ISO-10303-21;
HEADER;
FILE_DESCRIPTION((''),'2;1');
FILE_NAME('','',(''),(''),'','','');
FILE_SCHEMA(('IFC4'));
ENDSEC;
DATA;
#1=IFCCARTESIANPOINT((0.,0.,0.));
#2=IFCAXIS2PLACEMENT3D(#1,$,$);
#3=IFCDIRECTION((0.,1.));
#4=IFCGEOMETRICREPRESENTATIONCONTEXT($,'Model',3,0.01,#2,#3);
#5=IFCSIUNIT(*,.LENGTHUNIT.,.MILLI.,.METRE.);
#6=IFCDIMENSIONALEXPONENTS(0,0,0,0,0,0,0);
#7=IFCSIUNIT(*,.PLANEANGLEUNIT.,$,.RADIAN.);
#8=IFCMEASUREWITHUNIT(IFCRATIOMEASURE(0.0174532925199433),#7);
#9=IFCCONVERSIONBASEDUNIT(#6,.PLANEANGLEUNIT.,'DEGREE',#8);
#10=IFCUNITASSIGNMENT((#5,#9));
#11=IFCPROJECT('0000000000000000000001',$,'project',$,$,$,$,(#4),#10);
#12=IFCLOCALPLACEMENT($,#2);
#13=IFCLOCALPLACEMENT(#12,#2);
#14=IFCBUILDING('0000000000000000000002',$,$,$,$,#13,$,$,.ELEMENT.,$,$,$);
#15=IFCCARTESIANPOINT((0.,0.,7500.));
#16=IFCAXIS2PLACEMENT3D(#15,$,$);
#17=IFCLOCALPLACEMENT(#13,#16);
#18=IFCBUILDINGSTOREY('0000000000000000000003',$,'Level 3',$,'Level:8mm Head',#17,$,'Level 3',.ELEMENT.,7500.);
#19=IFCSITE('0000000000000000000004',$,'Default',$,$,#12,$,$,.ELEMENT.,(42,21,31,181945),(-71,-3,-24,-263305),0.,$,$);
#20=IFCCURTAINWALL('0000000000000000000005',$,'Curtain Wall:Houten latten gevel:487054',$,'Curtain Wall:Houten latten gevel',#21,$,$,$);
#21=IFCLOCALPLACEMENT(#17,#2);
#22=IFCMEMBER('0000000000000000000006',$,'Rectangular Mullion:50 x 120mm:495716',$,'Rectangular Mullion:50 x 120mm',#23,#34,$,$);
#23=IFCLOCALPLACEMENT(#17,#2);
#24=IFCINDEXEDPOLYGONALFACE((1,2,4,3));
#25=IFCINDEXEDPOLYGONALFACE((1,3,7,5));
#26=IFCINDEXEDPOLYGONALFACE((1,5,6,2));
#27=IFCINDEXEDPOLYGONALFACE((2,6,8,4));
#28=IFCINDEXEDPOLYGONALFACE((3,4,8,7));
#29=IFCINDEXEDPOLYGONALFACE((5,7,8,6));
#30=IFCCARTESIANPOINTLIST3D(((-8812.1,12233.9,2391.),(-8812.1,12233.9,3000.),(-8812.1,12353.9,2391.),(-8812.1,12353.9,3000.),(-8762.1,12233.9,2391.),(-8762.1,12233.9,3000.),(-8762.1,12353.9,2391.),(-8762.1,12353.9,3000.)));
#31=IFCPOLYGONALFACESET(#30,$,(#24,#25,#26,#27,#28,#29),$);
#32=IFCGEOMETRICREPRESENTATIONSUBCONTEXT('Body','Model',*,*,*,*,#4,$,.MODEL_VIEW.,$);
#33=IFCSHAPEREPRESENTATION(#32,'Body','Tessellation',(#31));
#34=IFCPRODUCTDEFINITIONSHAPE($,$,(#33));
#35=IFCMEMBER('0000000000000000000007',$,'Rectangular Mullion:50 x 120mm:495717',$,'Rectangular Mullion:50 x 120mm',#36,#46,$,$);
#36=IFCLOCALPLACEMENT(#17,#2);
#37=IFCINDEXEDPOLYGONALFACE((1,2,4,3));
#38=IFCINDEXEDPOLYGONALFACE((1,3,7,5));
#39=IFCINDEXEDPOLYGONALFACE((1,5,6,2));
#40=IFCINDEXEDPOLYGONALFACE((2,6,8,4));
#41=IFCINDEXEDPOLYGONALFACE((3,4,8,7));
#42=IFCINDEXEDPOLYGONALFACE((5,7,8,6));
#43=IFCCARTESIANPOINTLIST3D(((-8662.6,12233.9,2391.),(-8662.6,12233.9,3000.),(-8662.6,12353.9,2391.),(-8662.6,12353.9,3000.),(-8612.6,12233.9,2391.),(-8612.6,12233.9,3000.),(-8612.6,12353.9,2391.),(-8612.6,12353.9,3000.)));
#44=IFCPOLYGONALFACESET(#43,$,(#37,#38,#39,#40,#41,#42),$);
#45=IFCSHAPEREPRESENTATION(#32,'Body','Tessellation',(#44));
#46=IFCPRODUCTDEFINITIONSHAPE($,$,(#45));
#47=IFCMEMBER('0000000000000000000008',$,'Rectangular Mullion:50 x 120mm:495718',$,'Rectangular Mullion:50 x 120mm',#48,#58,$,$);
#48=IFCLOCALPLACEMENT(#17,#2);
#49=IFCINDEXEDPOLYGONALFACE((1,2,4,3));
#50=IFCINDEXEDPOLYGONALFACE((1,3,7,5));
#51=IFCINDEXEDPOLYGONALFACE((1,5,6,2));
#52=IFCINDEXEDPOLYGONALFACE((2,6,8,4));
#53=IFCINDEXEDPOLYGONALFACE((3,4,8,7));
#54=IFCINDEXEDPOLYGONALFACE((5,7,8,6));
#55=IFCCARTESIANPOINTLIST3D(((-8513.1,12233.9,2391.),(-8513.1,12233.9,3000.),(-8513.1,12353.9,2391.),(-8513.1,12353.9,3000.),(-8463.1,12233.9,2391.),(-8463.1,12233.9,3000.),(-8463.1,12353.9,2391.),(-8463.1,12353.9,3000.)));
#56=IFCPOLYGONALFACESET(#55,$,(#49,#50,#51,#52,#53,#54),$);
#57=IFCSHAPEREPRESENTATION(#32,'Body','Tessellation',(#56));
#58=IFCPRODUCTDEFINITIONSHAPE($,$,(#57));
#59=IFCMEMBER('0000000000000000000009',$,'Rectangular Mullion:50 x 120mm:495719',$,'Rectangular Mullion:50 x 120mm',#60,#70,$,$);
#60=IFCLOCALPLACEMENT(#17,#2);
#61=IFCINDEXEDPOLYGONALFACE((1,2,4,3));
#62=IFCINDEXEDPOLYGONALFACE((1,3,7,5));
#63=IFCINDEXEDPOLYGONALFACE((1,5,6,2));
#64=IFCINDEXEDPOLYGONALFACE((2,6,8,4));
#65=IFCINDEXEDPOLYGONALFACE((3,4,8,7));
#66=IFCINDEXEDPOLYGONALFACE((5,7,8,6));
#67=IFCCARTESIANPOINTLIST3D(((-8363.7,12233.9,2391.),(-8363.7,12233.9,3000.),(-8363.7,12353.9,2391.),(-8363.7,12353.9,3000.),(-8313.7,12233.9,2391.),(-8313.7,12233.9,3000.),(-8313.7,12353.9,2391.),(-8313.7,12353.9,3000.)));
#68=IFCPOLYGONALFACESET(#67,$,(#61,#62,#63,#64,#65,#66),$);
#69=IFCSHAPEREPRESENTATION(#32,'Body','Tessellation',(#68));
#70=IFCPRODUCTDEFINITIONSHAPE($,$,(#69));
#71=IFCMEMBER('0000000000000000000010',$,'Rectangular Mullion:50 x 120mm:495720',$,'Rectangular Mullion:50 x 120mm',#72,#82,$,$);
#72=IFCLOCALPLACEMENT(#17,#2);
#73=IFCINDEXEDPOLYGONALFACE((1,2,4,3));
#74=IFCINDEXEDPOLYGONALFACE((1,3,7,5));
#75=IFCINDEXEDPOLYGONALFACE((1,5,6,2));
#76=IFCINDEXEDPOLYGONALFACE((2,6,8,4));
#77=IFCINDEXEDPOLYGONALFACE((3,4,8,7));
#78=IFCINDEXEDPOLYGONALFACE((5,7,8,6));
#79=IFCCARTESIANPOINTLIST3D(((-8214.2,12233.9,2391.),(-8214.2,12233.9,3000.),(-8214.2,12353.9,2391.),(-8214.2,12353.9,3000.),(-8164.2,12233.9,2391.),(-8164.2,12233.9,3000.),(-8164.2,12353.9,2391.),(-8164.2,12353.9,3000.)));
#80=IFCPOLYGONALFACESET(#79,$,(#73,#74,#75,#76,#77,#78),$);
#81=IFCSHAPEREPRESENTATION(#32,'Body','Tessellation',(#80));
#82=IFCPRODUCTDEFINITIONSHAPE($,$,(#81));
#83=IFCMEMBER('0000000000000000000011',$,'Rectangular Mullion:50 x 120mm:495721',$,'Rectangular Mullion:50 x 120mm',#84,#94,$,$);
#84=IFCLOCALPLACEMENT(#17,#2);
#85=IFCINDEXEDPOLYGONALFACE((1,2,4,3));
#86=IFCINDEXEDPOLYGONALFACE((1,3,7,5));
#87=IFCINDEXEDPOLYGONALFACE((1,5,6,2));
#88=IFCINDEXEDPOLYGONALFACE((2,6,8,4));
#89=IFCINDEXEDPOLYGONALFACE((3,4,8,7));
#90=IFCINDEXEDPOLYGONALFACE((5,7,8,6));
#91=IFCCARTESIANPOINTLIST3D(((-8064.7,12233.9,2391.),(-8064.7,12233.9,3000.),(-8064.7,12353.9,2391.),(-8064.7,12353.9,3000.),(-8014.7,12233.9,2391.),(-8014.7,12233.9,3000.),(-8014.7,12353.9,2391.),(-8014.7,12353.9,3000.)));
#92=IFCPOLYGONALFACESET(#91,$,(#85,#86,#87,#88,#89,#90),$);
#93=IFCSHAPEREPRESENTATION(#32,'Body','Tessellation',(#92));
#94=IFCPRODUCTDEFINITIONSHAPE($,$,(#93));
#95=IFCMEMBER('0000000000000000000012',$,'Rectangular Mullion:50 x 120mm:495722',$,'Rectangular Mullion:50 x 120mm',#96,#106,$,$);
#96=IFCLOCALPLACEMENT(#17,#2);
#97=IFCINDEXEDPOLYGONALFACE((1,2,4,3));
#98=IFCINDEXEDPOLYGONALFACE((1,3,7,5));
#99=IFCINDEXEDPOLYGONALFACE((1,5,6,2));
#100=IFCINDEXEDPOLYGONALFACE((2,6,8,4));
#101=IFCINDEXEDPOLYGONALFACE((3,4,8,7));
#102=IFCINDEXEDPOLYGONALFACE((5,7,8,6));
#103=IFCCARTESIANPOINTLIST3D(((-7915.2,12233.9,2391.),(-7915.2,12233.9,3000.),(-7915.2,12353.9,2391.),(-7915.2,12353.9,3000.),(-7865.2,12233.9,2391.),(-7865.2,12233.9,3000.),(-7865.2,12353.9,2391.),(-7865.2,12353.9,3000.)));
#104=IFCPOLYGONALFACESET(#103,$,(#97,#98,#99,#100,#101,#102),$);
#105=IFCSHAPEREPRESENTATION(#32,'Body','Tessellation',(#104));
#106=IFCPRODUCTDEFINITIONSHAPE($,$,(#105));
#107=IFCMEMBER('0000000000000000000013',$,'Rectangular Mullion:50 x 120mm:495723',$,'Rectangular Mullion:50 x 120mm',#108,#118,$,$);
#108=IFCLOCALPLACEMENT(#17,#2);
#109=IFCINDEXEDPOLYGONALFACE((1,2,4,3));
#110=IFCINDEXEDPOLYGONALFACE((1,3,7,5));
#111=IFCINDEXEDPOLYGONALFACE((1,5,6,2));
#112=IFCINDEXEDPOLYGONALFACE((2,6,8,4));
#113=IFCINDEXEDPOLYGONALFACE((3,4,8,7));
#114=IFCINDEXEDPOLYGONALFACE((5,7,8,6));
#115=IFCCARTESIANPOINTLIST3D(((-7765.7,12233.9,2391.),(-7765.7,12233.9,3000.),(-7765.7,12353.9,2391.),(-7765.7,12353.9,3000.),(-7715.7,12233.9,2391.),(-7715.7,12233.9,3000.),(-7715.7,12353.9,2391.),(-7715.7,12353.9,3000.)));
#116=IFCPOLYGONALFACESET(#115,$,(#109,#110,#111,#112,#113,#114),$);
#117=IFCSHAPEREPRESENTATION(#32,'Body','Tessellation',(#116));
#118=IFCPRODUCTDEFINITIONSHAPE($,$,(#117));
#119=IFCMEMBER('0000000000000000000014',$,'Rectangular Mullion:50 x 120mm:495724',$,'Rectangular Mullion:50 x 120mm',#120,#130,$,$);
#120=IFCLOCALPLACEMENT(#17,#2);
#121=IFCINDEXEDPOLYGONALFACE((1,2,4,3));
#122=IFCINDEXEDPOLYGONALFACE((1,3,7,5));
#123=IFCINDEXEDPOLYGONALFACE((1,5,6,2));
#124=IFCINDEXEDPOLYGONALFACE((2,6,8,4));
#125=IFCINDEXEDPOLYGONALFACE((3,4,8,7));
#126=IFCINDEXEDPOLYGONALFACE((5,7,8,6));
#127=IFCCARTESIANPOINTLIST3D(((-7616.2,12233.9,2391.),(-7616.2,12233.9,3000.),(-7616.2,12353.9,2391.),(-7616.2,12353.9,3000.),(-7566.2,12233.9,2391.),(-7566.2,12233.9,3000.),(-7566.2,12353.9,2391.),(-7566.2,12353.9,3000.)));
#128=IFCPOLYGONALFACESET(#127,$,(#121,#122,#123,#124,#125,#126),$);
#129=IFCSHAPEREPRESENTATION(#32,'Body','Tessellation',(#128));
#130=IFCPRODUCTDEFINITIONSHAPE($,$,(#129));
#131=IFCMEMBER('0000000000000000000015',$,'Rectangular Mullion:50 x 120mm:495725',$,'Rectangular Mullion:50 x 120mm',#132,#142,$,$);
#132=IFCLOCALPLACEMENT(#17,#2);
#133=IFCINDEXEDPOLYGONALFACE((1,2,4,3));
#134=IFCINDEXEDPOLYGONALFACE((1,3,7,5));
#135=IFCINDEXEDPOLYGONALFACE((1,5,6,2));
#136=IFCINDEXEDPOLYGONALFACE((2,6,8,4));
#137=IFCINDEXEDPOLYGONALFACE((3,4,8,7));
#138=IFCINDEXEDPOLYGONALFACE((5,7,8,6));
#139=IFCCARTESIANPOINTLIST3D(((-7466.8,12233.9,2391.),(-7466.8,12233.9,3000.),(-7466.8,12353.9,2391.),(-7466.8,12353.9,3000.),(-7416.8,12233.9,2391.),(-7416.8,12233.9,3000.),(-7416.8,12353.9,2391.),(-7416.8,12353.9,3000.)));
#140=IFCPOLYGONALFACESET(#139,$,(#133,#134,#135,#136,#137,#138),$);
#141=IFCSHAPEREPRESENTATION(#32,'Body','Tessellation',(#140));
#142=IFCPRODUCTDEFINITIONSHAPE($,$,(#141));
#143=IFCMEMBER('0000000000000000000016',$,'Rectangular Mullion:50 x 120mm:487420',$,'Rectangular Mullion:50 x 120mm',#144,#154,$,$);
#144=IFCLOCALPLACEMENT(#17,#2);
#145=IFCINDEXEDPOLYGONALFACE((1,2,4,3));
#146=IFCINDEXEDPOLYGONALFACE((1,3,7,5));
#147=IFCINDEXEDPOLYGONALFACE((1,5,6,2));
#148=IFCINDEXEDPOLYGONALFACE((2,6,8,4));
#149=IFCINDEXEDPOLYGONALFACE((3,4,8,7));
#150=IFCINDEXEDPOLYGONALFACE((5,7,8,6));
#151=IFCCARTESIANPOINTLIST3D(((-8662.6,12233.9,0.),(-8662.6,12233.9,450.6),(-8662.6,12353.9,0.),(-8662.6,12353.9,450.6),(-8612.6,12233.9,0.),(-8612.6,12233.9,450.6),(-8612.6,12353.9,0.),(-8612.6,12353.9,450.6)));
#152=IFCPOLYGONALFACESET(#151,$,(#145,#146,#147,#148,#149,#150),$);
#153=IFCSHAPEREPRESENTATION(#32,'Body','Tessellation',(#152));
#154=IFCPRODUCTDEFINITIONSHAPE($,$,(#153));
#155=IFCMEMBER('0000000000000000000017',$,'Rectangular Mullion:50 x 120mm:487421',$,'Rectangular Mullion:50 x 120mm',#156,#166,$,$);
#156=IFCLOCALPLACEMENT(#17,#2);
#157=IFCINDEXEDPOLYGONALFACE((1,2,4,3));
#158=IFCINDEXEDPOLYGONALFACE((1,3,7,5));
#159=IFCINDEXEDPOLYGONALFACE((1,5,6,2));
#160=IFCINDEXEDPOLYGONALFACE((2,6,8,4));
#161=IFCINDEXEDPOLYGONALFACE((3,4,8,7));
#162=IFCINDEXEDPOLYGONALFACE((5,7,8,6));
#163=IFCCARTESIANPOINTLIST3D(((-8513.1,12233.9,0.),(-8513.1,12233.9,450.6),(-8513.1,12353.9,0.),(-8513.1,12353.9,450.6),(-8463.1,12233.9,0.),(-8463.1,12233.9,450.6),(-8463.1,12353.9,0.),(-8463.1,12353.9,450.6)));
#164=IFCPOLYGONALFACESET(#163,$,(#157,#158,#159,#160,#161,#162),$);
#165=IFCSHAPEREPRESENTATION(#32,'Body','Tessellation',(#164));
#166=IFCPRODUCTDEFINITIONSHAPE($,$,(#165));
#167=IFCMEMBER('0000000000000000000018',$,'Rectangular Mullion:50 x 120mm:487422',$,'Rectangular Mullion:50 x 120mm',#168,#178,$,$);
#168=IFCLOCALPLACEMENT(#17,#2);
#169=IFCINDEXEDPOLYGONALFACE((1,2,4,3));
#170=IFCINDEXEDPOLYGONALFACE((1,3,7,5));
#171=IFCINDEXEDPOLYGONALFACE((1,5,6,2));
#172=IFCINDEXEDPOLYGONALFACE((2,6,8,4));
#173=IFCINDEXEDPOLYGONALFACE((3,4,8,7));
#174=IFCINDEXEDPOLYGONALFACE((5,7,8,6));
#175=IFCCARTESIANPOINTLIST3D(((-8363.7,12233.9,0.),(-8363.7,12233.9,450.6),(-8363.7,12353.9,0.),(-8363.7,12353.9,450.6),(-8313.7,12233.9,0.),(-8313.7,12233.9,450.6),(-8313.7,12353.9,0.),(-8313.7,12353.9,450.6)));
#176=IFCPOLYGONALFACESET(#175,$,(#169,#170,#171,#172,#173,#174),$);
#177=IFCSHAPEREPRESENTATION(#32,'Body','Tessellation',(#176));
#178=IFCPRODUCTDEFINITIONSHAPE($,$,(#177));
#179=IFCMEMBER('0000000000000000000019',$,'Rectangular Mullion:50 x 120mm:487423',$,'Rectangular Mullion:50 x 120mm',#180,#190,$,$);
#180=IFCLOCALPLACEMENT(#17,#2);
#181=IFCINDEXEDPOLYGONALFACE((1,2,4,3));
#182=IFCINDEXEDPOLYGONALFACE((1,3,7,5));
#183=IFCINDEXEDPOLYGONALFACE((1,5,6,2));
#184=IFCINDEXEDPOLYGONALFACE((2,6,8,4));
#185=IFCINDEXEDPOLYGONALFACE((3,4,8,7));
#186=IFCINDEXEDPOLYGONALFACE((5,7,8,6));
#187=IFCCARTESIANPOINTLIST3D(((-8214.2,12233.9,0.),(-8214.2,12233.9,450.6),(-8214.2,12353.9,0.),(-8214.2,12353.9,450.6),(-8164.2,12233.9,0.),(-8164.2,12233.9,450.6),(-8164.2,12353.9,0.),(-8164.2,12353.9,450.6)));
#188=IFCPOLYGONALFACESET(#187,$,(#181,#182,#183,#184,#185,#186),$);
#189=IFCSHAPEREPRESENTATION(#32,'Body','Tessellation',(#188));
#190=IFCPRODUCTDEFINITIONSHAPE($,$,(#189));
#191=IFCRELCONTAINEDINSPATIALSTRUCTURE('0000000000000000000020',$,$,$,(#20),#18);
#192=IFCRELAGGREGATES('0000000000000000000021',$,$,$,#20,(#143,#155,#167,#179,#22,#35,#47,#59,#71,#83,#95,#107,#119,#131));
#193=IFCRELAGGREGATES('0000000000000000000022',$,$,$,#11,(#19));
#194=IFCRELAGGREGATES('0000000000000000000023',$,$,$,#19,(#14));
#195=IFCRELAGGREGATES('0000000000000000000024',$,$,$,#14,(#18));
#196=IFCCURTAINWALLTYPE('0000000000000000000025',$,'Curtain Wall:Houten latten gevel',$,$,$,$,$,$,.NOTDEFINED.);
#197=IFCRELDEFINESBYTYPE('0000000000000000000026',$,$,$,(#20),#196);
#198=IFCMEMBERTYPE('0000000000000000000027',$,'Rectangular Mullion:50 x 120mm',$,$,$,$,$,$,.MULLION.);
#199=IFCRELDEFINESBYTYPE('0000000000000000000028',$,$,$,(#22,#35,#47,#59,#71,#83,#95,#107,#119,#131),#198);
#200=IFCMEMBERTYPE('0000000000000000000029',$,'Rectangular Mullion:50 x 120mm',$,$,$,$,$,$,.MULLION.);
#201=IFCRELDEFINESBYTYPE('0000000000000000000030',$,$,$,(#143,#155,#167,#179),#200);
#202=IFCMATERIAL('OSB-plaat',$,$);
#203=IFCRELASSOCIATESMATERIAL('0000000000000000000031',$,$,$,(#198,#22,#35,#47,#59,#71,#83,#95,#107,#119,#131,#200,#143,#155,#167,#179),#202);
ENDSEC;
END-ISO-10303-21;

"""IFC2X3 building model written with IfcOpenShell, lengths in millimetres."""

from ifc_helpers import new_model, entity, si_unit, converted_unit, direction, frame, origin, origin_2d_with_axis, place, context, subcontext, project, spatial, rectangle, extrude, source, transform, mapped, material, type_object, type_shapes, element, aggregate, save


model = new_model("IFC2X3")

# Units and contexts
model_context = context("Model", 3, precision=0.01, world=origin(), true_north=direction((0.0, 1.0)))
body_context = subcontext(model_context, "Body", "Model", "MODEL_VIEW")
ifc_project = project(units=[si_unit("LENGTHUNIT", "METRE", prefix="MILLI"), converted_unit("PLANEANGLEUNIT", "DEGREE", entity("IfcRatioMeasure", 0.0174532925199433), si_unit("PLANEANGLEUNIT", "RADIAN"), dimensions=[0, 0, 0, 0, 0, 0, 0])], contexts=[model_context])

# Site, building, storey
site_placement = place(None, frame((0.0, 0.0, 0.0)))
site = spatial("IfcSite", under=ifc_project, at=site_placement, Name="Default", CompositionType="ELEMENT", RefLatitude=(42, 21, 31, 181945), RefLongitude=(-71, -3, -24, -263305), RefElevation=0.0)
building_placement = place(site_placement, origin())
building = spatial("IfcBuilding", under=site, at=building_placement, CompositionType="ELEMENT")
storey_placement = place(building_placement, frame((0.0, 0.0, 7500.0)))
storey = spatial("IfcBuildingStorey", under=building, at=storey_placement, Name="Level 3", ObjectType="Level:8mm Head", LongName="Level 3", CompositionType="ELEMENT", Elevation=7500.0)

# Curtain wall, members
curtain_wall_type = type_object("IfcCurtainWallType", Name="Curtain Wall:Houten latten gevel", PredefinedType="NOTDEFINED")
curtain_wall_placement = place(storey_placement, frame((0.0, 0.0, -7500.0)))
curtain_wall = element("IfcCurtainWall", 1, at=curtain_wall_placement, inside=storey, type_object=curtain_wall_type, Name="Curtain Wall:Houten latten gevel:487054", ObjectType="Curtain Wall:Houten latten gevel")
ifc_material_1 = material(Name="OSB-plaat")
member_type_1 = type_object("IfcMemberType", Name="Rectangular Mullion:50 x 120mm", PredefinedType="MULLION", material=ifc_material_1)
shared_shape_1 = source(origin(), body_context, "Body", "SweptSolid", [
    extrude(rectangle(XDim=120.0, YDim=50.0, at=origin_2d_with_axis()), frame((0.0, 0.0, -609.0), z_axis=(0.0, 0.0, 1.0), x_axis=(0.0, -1.0, 0.0)), (0.0, 0.0, 1.0), 609.0),
])
type_shapes(member_type_1, [shared_shape_1])
member_1_placement = place(storey_placement, frame((-8787.1, 12293.9, 2391.0), z_axis=(0.0, 0.0, -1.0), x_axis=(1.0, 0.0, 0.0)))
member_1 = element("IfcMember", 2, at=member_1_placement, type_object=member_type_1, material=ifc_material_1, Name="Rectangular Mullion:50 x 120mm:495716", ObjectType="Rectangular Mullion:50 x 120mm", context=body_context, shape_type="MappedRepresentation", body=[
    mapped(shared_shape_1, transform((0.0, 0.0, 0.0), scale=1.0)),
])
member_2_placement = place(storey_placement, frame((-8637.6, 12293.9, 2391.0), z_axis=(0.0, 0.0, -1.0), x_axis=(1.0, 0.0, 0.0)))
member_2 = element("IfcMember", 3, at=member_2_placement, type_object=member_type_1, material=ifc_material_1, Name="Rectangular Mullion:50 x 120mm:495717", ObjectType="Rectangular Mullion:50 x 120mm", context=body_context, shape_type="MappedRepresentation", body=[
    mapped(shared_shape_1, transform((0.0, 0.0, 0.0), scale=1.0)),
])
member_3_placement = place(storey_placement, frame((-8488.1, 12293.9, 2391.0), z_axis=(0.0, 0.0, -1.0), x_axis=(1.0, 0.0, 0.0)))
member_3 = element("IfcMember", 4, at=member_3_placement, type_object=member_type_1, material=ifc_material_1, Name="Rectangular Mullion:50 x 120mm:495718", ObjectType="Rectangular Mullion:50 x 120mm", context=body_context, shape_type="MappedRepresentation", body=[
    mapped(shared_shape_1, transform((0.0, 0.0, 0.0), scale=1.0)),
])
member_4_placement = place(storey_placement, frame((-8338.7, 12293.9, 2391.0), z_axis=(0.0, 0.0, -1.0), x_axis=(1.0, 0.0, 0.0)))
member_4 = element("IfcMember", 5, at=member_4_placement, type_object=member_type_1, material=ifc_material_1, Name="Rectangular Mullion:50 x 120mm:495719", ObjectType="Rectangular Mullion:50 x 120mm", context=body_context, shape_type="MappedRepresentation", body=[
    mapped(shared_shape_1, transform((0.0, 0.0, 0.0), scale=1.0)),
])
member_5_placement = place(storey_placement, frame((-8189.2, 12293.9, 2391.0), z_axis=(0.0, 0.0, -1.0), x_axis=(1.0, 0.0, 0.0)))
member_5 = element("IfcMember", 6, at=member_5_placement, type_object=member_type_1, material=ifc_material_1, Name="Rectangular Mullion:50 x 120mm:495720", ObjectType="Rectangular Mullion:50 x 120mm", context=body_context, shape_type="MappedRepresentation", body=[
    mapped(shared_shape_1, transform((0.0, 0.0, 0.0), scale=1.0)),
])
member_6_placement = place(storey_placement, frame((-8039.7, 12293.9, 2391.0), z_axis=(0.0, 0.0, -1.0), x_axis=(1.0, 0.0, 0.0)))
member_6 = element("IfcMember", 7, at=member_6_placement, type_object=member_type_1, material=ifc_material_1, Name="Rectangular Mullion:50 x 120mm:495721", ObjectType="Rectangular Mullion:50 x 120mm", context=body_context, shape_type="MappedRepresentation", body=[
    mapped(shared_shape_1, transform((0.0, 0.0, 0.0), scale=1.0)),
])
member_7_placement = place(storey_placement, frame((-7890.2, 12293.9, 2391.0), z_axis=(0.0, 0.0, -1.0), x_axis=(1.0, 0.0, 0.0)))
member_7 = element("IfcMember", 8, at=member_7_placement, type_object=member_type_1, material=ifc_material_1, Name="Rectangular Mullion:50 x 120mm:495722", ObjectType="Rectangular Mullion:50 x 120mm", context=body_context, shape_type="MappedRepresentation", body=[
    mapped(shared_shape_1, transform((0.0, 0.0, 0.0), scale=1.0)),
])
member_8_placement = place(storey_placement, frame((-7740.7, 12293.9, 2391.0), z_axis=(0.0, 0.0, -1.0), x_axis=(1.0, 0.0, 0.0)))
member_8 = element("IfcMember", 9, at=member_8_placement, type_object=member_type_1, material=ifc_material_1, Name="Rectangular Mullion:50 x 120mm:495723", ObjectType="Rectangular Mullion:50 x 120mm", context=body_context, shape_type="MappedRepresentation", body=[
    mapped(shared_shape_1, transform((0.0, 0.0, 0.0), scale=1.0)),
])
member_9_placement = place(storey_placement, frame((-7591.2, 12293.9, 2391.0), z_axis=(0.0, 0.0, -1.0), x_axis=(1.0, 0.0, 0.0)))
member_9 = element("IfcMember", 10, at=member_9_placement, type_object=member_type_1, material=ifc_material_1, Name="Rectangular Mullion:50 x 120mm:495724", ObjectType="Rectangular Mullion:50 x 120mm", context=body_context, shape_type="MappedRepresentation", body=[
    mapped(shared_shape_1, transform((0.0, 0.0, 0.0), scale=1.0)),
])
member_10_placement = place(storey_placement, frame((-7441.8, 12293.9, 2391.0), z_axis=(0.0, 0.0, -1.0), x_axis=(1.0, 0.0, 0.0)))
member_10 = element("IfcMember", 11, at=member_10_placement, type_object=member_type_1, material=ifc_material_1, Name="Rectangular Mullion:50 x 120mm:495725", ObjectType="Rectangular Mullion:50 x 120mm", context=body_context, shape_type="MappedRepresentation", body=[
    mapped(shared_shape_1, transform((0.0, 0.0, 0.0), scale=1.0)),
])
member_type_2 = type_object("IfcMemberType", Name="Rectangular Mullion:50 x 120mm", PredefinedType="MULLION", material=ifc_material_1)
shared_shape_2 = source(origin(), body_context, "Body", "SweptSolid", [
    extrude(rectangle(XDim=120.0, YDim=50.0, at=origin_2d_with_axis()), frame((0.0, 0.0, -450.6), z_axis=(0.0, 0.0, 1.0), x_axis=(0.0, -1.0, 0.0)), (0.0, 0.0, 1.0), 450.6),
])
type_shapes(member_type_2, [shared_shape_2])
member_11_placement = place(storey_placement, frame((-8637.6, 12293.9, 0.0), z_axis=(0.0, 0.0, -1.0), x_axis=(1.0, 0.0, 0.0)))
member_11 = element("IfcMember", 12, at=member_11_placement, type_object=member_type_2, material=ifc_material_1, Name="Rectangular Mullion:50 x 120mm:487420", ObjectType="Rectangular Mullion:50 x 120mm", context=body_context, shape_type="MappedRepresentation", body=[
    mapped(shared_shape_2, transform((0.0, 0.0, 0.0), scale=1.0)),
])
member_12_placement = place(storey_placement, frame((-8488.1, 12293.9, 0.0), z_axis=(0.0, 0.0, -1.0), x_axis=(1.0, 0.0, 0.0)))
member_12 = element("IfcMember", 13, at=member_12_placement, type_object=member_type_2, material=ifc_material_1, Name="Rectangular Mullion:50 x 120mm:487421", ObjectType="Rectangular Mullion:50 x 120mm", context=body_context, shape_type="MappedRepresentation", body=[
    mapped(shared_shape_2, transform((0.0, 0.0, 0.0), scale=1.0)),
])
member_13_placement = place(storey_placement, frame((-8338.7, 12293.9, 0.0), z_axis=(0.0, 0.0, -1.0), x_axis=(1.0, 0.0, 0.0)))
member_13 = element("IfcMember", 14, at=member_13_placement, type_object=member_type_2, material=ifc_material_1, Name="Rectangular Mullion:50 x 120mm:487422", ObjectType="Rectangular Mullion:50 x 120mm", context=body_context, shape_type="MappedRepresentation", body=[
    mapped(shared_shape_2, transform((0.0, 0.0, 0.0), scale=1.0)),
])
member_14_placement = place(storey_placement, frame((-8189.2, 12293.9, 0.0), z_axis=(0.0, 0.0, -1.0), x_axis=(1.0, 0.0, 0.0)))
member_14 = element("IfcMember", 15, at=member_14_placement, type_object=member_type_2, material=ifc_material_1, Name="Rectangular Mullion:50 x 120mm:487423", ObjectType="Rectangular Mullion:50 x 120mm", context=body_context, shape_type="MappedRepresentation", body=[
    mapped(shared_shape_2, transform((0.0, 0.0, 0.0), scale=1.0)),
])
aggregate(curtain_wall, [member_11, member_12, member_13, member_14, member_1, member_2, member_3, member_4, member_5, member_6, member_7, member_8, member_9, member_10])

save(model, "model.ifc")
